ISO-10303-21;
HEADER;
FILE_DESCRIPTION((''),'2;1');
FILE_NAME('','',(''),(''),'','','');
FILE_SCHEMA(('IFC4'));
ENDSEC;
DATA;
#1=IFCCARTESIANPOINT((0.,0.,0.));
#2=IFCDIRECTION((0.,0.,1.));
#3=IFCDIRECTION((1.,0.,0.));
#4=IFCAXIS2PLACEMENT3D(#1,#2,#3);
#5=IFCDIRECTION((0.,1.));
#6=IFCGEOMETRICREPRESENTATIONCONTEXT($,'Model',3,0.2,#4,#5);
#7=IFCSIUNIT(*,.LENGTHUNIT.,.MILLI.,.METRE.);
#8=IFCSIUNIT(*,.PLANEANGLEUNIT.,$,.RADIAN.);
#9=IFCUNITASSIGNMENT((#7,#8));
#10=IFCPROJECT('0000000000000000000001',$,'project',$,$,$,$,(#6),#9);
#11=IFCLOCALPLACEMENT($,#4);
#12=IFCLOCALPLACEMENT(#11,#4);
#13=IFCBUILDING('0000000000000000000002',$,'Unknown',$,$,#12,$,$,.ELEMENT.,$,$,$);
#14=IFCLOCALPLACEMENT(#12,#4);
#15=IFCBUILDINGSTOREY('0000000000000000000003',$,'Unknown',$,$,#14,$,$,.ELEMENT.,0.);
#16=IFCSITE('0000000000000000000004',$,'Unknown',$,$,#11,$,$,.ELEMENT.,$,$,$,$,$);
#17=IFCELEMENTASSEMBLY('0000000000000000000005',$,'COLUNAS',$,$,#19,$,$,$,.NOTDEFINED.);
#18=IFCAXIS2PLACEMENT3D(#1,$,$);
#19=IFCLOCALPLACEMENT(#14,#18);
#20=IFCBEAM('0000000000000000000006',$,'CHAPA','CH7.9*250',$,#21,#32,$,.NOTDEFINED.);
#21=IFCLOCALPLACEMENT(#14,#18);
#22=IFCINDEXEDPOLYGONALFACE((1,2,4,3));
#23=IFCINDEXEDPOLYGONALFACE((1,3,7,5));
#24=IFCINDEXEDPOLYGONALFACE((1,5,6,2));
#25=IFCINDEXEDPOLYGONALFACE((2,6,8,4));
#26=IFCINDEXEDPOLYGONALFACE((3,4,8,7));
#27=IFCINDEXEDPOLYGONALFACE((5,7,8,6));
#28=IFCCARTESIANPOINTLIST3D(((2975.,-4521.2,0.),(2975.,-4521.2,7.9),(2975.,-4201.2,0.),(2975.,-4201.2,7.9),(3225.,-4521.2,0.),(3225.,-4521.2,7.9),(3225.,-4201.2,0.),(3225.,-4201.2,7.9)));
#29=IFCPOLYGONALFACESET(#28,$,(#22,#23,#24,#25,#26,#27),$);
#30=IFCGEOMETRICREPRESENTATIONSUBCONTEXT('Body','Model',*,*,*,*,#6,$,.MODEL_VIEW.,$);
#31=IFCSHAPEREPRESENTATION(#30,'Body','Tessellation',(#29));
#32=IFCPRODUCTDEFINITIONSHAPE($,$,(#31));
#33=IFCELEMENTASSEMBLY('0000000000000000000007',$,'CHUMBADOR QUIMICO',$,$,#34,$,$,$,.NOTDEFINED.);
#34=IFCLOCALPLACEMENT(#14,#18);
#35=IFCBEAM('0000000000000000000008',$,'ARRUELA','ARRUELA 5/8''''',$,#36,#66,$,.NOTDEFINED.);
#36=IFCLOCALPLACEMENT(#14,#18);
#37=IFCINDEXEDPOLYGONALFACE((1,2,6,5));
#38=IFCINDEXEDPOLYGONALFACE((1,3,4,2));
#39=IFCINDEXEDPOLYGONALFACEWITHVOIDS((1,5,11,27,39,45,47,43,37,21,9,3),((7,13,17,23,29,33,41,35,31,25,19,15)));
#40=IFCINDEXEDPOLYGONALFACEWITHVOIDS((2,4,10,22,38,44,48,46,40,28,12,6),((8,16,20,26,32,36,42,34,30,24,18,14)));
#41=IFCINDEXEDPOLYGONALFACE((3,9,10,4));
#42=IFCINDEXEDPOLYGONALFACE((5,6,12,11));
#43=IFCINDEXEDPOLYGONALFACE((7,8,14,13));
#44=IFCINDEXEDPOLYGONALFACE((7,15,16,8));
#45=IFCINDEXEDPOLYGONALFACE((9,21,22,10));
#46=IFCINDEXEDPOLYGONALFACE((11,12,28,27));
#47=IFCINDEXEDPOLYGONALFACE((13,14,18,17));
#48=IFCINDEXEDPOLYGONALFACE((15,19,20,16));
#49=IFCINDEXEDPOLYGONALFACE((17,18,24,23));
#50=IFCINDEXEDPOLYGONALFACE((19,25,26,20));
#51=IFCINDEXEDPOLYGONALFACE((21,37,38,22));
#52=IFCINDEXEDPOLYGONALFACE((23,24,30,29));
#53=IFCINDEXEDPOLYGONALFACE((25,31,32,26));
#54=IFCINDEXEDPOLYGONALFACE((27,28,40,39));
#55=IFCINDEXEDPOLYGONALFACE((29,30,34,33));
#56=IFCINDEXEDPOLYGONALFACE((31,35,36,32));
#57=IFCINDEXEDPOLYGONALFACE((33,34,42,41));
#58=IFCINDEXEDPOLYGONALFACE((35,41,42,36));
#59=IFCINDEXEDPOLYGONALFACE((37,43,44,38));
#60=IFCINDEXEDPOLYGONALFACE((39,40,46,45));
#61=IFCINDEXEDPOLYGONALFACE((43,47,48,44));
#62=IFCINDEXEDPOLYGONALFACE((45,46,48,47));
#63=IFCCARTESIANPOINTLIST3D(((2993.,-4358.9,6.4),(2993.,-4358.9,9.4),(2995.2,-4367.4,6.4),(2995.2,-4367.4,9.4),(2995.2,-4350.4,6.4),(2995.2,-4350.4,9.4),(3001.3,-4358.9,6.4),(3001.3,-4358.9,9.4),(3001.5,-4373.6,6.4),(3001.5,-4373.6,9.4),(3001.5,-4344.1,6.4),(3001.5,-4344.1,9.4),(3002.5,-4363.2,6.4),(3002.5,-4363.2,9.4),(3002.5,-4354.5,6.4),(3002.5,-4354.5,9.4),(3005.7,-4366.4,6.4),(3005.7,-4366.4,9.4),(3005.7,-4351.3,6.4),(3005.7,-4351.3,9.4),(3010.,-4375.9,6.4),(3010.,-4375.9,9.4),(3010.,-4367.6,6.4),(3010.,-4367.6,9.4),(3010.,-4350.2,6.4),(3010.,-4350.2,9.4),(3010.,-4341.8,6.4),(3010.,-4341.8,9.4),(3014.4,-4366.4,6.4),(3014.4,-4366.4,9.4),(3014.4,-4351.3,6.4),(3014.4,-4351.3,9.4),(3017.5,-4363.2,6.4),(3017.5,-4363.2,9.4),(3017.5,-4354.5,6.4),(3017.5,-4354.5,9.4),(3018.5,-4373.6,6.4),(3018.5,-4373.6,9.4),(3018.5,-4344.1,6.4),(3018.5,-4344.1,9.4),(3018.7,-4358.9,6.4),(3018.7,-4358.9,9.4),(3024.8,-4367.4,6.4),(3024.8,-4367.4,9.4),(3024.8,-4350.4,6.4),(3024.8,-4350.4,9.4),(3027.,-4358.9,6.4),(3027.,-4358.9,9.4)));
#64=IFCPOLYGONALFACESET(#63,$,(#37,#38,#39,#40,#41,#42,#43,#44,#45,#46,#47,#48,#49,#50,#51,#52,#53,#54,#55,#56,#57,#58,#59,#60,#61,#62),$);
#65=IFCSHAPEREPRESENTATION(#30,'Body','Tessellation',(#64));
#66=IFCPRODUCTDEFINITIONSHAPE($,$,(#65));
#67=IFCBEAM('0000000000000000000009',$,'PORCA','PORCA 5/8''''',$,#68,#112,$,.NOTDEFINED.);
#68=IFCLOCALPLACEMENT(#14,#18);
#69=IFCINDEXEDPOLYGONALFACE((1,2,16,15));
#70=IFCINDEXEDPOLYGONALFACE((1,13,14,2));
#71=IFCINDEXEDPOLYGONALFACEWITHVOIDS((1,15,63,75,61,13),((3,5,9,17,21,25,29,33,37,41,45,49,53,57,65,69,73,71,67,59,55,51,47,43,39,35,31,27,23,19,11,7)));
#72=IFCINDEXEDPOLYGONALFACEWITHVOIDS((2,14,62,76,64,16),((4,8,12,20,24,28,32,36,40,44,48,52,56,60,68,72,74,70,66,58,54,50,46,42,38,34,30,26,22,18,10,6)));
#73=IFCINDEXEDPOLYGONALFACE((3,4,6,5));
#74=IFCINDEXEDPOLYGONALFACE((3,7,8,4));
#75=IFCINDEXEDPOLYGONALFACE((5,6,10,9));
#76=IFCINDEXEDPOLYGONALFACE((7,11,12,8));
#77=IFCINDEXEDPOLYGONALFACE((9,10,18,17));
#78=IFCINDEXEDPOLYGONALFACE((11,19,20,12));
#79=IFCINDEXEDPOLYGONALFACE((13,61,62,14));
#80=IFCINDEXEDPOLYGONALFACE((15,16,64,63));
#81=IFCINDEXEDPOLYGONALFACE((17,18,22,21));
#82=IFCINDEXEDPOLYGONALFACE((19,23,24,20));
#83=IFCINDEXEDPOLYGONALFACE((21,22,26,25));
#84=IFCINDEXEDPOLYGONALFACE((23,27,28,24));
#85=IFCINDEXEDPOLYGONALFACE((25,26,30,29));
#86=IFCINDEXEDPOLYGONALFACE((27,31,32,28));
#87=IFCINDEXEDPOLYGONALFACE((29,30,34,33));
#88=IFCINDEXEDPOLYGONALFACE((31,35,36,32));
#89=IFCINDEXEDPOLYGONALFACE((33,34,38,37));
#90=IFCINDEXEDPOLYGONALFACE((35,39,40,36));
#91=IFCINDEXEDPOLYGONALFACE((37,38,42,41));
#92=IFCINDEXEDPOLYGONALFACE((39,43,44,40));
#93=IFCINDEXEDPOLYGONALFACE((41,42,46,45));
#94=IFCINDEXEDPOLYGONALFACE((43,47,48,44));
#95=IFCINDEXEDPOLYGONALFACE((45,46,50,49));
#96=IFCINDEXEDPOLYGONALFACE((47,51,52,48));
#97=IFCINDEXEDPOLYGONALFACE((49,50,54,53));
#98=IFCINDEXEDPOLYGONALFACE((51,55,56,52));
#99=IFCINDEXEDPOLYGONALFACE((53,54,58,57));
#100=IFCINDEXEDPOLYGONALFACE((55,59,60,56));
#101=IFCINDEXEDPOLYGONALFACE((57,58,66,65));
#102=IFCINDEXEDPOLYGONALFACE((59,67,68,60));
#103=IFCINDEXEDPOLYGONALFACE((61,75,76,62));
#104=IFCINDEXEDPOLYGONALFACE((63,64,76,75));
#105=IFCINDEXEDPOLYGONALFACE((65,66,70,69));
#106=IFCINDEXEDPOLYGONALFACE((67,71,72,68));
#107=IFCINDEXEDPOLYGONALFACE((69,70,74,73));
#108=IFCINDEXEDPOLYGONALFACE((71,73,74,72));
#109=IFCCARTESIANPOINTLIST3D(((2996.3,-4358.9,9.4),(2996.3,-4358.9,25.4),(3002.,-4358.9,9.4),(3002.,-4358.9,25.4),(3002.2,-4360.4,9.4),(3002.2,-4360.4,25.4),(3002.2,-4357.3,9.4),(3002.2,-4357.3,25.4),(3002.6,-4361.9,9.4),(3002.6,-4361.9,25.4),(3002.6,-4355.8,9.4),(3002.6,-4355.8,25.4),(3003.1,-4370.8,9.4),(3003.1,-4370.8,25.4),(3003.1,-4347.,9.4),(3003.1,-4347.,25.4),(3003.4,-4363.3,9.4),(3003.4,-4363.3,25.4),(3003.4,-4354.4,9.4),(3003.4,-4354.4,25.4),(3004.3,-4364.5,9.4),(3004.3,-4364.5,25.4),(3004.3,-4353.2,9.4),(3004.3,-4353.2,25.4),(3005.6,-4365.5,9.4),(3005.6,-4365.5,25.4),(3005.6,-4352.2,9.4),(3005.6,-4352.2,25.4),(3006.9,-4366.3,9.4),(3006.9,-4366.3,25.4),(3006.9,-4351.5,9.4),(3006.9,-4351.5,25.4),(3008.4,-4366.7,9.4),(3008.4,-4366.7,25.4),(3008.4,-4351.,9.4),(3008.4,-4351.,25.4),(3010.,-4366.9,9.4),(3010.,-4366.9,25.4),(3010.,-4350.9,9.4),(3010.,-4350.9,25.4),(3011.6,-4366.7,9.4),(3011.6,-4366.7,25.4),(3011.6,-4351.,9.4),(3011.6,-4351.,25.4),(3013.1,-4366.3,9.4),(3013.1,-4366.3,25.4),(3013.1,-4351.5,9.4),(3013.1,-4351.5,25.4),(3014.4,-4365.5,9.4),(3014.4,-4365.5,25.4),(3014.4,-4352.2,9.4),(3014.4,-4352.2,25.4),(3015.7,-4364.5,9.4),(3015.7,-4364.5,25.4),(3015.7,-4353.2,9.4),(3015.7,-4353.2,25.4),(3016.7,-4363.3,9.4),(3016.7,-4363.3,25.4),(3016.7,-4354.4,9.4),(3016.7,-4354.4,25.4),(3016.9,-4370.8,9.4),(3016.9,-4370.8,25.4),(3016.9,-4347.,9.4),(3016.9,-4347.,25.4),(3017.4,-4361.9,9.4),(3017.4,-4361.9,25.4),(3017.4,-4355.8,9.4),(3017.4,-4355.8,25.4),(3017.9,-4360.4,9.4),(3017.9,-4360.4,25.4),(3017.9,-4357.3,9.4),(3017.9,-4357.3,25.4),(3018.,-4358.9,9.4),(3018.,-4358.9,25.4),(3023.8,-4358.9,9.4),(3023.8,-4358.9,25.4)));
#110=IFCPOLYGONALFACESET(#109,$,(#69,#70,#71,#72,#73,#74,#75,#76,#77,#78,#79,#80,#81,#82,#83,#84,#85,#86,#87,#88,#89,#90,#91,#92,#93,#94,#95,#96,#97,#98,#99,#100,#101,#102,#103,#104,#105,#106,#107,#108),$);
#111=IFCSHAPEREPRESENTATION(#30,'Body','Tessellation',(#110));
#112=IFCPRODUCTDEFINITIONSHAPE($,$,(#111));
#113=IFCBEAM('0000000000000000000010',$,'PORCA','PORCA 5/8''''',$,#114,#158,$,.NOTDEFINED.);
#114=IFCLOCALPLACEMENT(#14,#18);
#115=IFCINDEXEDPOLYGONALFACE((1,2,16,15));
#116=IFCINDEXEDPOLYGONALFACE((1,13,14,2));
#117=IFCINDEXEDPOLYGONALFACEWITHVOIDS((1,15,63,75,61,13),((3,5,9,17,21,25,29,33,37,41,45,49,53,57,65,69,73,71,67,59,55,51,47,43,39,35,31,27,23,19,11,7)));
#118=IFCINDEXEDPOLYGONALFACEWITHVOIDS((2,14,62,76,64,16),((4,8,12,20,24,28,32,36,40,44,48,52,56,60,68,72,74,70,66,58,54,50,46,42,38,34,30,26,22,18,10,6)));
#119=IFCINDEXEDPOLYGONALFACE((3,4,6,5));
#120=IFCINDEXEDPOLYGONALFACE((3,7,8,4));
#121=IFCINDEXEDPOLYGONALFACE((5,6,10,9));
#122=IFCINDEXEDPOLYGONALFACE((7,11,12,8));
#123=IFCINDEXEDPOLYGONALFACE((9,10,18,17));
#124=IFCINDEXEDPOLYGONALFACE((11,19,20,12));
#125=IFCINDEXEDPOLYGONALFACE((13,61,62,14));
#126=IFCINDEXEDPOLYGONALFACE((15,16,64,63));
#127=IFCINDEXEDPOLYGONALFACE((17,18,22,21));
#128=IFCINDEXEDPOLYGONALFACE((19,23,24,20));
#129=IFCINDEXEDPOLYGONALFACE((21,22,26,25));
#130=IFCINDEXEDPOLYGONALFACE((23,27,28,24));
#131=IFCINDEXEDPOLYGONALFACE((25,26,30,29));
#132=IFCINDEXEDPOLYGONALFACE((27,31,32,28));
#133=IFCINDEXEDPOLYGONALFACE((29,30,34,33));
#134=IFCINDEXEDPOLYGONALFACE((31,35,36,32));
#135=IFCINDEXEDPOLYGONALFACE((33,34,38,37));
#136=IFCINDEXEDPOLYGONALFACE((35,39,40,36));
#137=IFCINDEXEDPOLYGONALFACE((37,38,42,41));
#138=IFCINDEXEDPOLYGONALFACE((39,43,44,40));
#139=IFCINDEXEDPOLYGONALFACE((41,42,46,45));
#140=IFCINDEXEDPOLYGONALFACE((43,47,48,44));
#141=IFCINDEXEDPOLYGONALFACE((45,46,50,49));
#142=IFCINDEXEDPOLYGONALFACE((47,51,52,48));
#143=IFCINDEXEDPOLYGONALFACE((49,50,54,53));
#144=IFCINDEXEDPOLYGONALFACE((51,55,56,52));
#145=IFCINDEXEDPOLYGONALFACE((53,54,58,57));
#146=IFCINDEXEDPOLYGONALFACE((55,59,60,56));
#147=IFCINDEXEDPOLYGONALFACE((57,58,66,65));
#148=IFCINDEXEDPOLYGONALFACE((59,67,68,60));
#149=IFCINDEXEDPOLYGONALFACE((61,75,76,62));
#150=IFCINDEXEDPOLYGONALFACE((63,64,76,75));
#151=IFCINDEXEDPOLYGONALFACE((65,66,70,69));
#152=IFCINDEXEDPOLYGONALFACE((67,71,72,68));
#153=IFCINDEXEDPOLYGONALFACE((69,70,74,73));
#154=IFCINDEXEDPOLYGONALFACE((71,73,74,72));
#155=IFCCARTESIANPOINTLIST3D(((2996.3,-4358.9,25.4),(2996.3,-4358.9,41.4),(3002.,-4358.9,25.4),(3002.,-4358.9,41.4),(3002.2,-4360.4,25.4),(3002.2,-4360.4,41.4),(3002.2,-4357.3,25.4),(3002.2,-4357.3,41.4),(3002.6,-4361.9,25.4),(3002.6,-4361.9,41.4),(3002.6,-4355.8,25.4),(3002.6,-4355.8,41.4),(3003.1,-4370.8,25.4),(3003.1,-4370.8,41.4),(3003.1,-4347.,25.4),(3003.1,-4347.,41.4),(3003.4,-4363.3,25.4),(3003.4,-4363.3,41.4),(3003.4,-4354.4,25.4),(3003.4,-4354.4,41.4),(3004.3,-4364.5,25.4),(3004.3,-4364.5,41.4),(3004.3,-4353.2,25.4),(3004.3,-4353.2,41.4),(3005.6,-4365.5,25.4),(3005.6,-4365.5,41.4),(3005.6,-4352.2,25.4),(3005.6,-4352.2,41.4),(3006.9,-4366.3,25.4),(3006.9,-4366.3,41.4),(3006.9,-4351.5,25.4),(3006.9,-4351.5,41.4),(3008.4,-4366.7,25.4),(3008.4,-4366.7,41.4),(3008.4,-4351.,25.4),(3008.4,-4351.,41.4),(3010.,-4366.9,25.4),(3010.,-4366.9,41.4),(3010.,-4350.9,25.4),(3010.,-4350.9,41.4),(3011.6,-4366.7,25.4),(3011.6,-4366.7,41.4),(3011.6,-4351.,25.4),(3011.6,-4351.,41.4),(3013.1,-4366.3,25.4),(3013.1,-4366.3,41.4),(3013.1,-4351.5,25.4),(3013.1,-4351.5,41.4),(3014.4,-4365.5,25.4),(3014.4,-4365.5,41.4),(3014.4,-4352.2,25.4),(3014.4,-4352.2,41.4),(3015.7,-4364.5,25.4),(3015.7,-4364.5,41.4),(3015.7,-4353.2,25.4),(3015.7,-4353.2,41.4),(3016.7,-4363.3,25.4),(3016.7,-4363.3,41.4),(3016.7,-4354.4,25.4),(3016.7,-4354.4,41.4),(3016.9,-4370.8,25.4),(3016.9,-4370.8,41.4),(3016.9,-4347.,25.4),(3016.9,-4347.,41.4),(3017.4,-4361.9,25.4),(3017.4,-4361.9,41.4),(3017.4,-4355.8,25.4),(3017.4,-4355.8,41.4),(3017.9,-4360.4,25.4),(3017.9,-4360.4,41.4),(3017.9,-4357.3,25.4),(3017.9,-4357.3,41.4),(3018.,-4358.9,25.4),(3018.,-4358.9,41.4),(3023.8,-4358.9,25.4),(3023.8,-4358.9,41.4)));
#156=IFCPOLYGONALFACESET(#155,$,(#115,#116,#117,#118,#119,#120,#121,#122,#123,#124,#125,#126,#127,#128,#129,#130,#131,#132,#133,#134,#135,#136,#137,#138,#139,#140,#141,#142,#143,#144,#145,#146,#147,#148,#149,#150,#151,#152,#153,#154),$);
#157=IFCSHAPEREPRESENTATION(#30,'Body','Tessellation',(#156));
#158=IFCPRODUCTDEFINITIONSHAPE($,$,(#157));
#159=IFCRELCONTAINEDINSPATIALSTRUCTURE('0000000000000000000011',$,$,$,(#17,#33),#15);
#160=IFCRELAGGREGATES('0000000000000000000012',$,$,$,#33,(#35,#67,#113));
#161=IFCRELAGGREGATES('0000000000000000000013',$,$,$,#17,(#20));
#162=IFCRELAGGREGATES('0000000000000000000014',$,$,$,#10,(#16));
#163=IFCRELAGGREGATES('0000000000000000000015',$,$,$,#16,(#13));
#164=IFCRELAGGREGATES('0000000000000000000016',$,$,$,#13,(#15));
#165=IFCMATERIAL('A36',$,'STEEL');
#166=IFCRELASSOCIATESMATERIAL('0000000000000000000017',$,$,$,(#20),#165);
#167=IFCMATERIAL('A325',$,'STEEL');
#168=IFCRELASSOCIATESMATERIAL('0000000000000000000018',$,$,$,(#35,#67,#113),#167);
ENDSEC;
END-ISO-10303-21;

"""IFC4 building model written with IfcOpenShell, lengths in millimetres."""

from ifc_helpers import new_model, si_unit, direction, frame, origin_with_axes, place, context, subcontext, project, spatial, line, indexed_curve, outline, extrude, material, element, aggregate, save


model = new_model("IFC4")

# Units and contexts
model_context = context("Model", 3, precision=0.2, world=origin_with_axes(), true_north=direction((0.0, 1.0)))
body_context = subcontext(model_context, "Body", "Model", "MODEL_VIEW")
ifc_project = project(units=[si_unit("LENGTHUNIT", "METRE", prefix="MILLI"), si_unit("PLANEANGLEUNIT", "RADIAN")], contexts=[model_context])

# Site, building, storey
site_placement = place(None, origin_with_axes())
site = spatial("IfcSite", under=ifc_project, at=site_placement, Name="Unknown", CompositionType="ELEMENT")
building_placement = place(site_placement, origin_with_axes())
building = spatial("IfcBuilding", under=site, at=building_placement, Name="Unknown", CompositionType="ELEMENT")
storey_placement = place(building_placement, origin_with_axes())
storey = spatial("IfcBuildingStorey", under=building, at=storey_placement, Name="Unknown", CompositionType="ELEMENT", Elevation=0.0)

# Element assembly, beam
assembly_1_placement = place(storey_placement, frame((3100.0, -4361.2, 4997.7), z_axis=(-1.0, 0.0, 0.0), x_axis=(0.0, 0.0, -1.0)))
assembly_1 = element("IfcElementAssembly", 1, at=assembly_1_placement, inside=storey, Name="COLUNAS", PredefinedType="NOTDEFINED")
ifc_material_1 = material(Name="A36", Category="STEEL")
beam_1_placement = place(assembly_1_placement, frame((4993.8, -160.0, 0.0), z_axis=(-1.0, 0.0, 0.0), x_axis=(0.0, 1.0, 0.0)))
beam_1 = element("IfcBeam", 2, at=beam_1_placement, material=ifc_material_1, Name="CHAPA", Description="CH7.9*250", PredefinedType="NOTDEFINED", context=body_context, shape_type="SolidModel", body=[
    extrude(outline(indexed_curve([(-4.0, -125.0), (4.0, -125.0), (4.0, 125.0), (-4.0, 125.0)], segments=[line(1, 2, 3, 4, 1)])), frame((0.0, 0.0, 0.0), z_axis=(-1.0, 0.0, 0.0), x_axis=(0.0, 0.0, 1.0)), (0.0, 0.0, -1.0), 320.0),
])

# Element assembly, beams
assembly_2_placement = place(storey_placement, frame((3010.0, -4358.9, -53.6), z_axis=(0.0, -1.0, 0.0), x_axis=(0.0, 0.0, -1.0)))
assembly_2 = element("IfcElementAssembly", 3, at=assembly_2_placement, inside=storey, Name="CHUMBADOR QUIMICO", PredefinedType="NOTDEFINED")
ifc_material_2 = material(Name="A325", Category="STEEL")
beam_2_placement = place(assembly_2_placement, frame((-63.0, 0.0, 0.0), z_axis=(0.0, 0.0, 1.0), x_axis=(1.0, 0.0, 0.0)))
beam_2 = element("IfcBeam", 4, at=beam_2_placement, material=ifc_material_2, Name="ARRUELA", Description="ARRUELA 5/8''", PredefinedType="NOTDEFINED", context=body_context, shape_type="SolidModel", body=[
    extrude(outline(indexed_curve([(17.0, 0.0), (14.8, 8.5), (8.5, 14.8), (0.0, 17.0), (-8.5, 14.8), (-14.8, 8.5), (-17.0, 0.0), (-14.8, -8.5), (-8.5, -14.8), (0.0, -17.0), (8.5, -14.8), (14.8, -8.5)], segments=[line(1, 2, 3, 4, 5, 6, 7, 8, 9, 10, 11, 12, 1)]), holes=[indexed_curve([(8.7, 0.0), (7.5, -4.3), (4.3, -7.5), (0.0, -8.7), (-4.3, -7.5), (-7.5, -4.3), (-8.7, 0.0), (-7.5, 4.3), (-4.3, 7.5), (0.0, 8.7), (4.3, 7.5), (7.5, 4.3)], segments=[line(1, 2, 3, 4, 5, 6, 7, 8, 9, 10, 11, 12, 1)])]), frame((0.0, 0.0, 0.0), z_axis=(-1.0, 0.0, 0.0), x_axis=(0.0, 0.0, 1.0)), (0.0, 0.0, -1.0), 3.0),
])
beam_3_placement = place(assembly_2_placement, frame((-79.0, 0.0, 0.0), z_axis=(0.0, 0.0, 1.0), x_axis=(1.0, 0.0, 0.0)))
beam_3 = element("IfcBeam", 5, at=beam_3_placement, material=ifc_material_2, Name="PORCA", Description="PORCA 5/8''", PredefinedType="NOTDEFINED", context=body_context, shape_type="SolidModel", body=[
    extrude(outline(indexed_curve([(0.0, 13.8), (-11.9, 6.9), (-11.9, -6.9), (0.0, -13.8), (11.9, -6.9), (11.9, 6.9)], segments=[line(1, 2, 3, 4, 5, 6, 1)]), holes=[indexed_curve([(7.8, 1.6), (8.0, 0.0), (7.8, -1.6), (7.4, -3.1), (6.7, -4.4), (5.7, -5.7), (4.4, -6.7), (3.1, -7.4), (1.6, -7.8), (0.0, -8.0), (-1.6, -7.8), (-3.1, -7.4), (-4.4, -6.7), (-5.7, -5.7), (-6.7, -4.4), (-7.4, -3.1), (-7.8, -1.6), (-8.0, 0.0), (-7.8, 1.6), (-7.4, 3.1), (-6.7, 4.4), (-5.7, 5.7), (-4.4, 6.7), (-3.1, 7.4), (-1.6, 7.8), (0.0, 8.0), (1.6, 7.8), (3.1, 7.4), (4.4, 6.7), (5.7, 5.7), (6.7, 4.4), (7.4, 3.1)], segments=[line(1, 2, 3, 4, 5, 6, 7, 8, 9, 10, 11, 12, 13, 14, 15, 16, 17, 18, 19, 20, 21, 22, 23, 24, 25, 26, 27, 28, 29, 30, 31, 32, 1)])]), frame((0.0, 0.0, 0.0), z_axis=(-1.0, 0.0, 0.0), x_axis=(0.0, 0.0, 1.0)), (0.0, 0.0, -1.0), 16.0),
])
beam_4_placement = place(assembly_2_placement, frame((-95.0, 0.0, 0.0), z_axis=(0.0, 0.0, 1.0), x_axis=(1.0, 0.0, 0.0)))
beam_4 = element("IfcBeam", 6, at=beam_4_placement, material=ifc_material_2, Name="PORCA", Description="PORCA 5/8''", PredefinedType="NOTDEFINED", context=body_context, shape_type="SolidModel", body=[
    extrude(outline(indexed_curve([(0.0, 13.8), (-11.9, 6.9), (-11.9, -6.9), (0.0, -13.8), (11.9, -6.9), (11.9, 6.9)], segments=[line(1, 2, 3, 4, 5, 6, 1)]), holes=[indexed_curve([(7.8, 1.6), (8.0, 0.0), (7.8, -1.6), (7.4, -3.1), (6.7, -4.4), (5.7, -5.7), (4.4, -6.7), (3.1, -7.4), (1.6, -7.8), (0.0, -8.0), (-1.6, -7.8), (-3.1, -7.4), (-4.4, -6.7), (-5.7, -5.7), (-6.7, -4.4), (-7.4, -3.1), (-7.8, -1.6), (-8.0, 0.0), (-7.8, 1.6), (-7.4, 3.1), (-6.7, 4.4), (-5.7, 5.7), (-4.4, 6.7), (-3.1, 7.4), (-1.6, 7.8), (0.0, 8.0), (1.6, 7.8), (3.1, 7.4), (4.4, 6.7), (5.7, 5.7), (6.7, 4.4), (7.4, 3.1)], segments=[line(1, 2, 3, 4, 5, 6, 7, 8, 9, 10, 11, 12, 13, 14, 15, 16, 17, 18, 19, 20, 21, 22, 23, 24, 25, 26, 27, 28, 29, 30, 31, 32, 1)])]), frame((0.0, 0.0, 0.0), z_axis=(-1.0, 0.0, 0.0), x_axis=(0.0, 0.0, 1.0)), (0.0, 0.0, -1.0), 16.0),
])
aggregate(assembly_2, [beam_2, beam_3, beam_4])

aggregate(assembly_1, [beam_1])

save(model, "model.ifc")
